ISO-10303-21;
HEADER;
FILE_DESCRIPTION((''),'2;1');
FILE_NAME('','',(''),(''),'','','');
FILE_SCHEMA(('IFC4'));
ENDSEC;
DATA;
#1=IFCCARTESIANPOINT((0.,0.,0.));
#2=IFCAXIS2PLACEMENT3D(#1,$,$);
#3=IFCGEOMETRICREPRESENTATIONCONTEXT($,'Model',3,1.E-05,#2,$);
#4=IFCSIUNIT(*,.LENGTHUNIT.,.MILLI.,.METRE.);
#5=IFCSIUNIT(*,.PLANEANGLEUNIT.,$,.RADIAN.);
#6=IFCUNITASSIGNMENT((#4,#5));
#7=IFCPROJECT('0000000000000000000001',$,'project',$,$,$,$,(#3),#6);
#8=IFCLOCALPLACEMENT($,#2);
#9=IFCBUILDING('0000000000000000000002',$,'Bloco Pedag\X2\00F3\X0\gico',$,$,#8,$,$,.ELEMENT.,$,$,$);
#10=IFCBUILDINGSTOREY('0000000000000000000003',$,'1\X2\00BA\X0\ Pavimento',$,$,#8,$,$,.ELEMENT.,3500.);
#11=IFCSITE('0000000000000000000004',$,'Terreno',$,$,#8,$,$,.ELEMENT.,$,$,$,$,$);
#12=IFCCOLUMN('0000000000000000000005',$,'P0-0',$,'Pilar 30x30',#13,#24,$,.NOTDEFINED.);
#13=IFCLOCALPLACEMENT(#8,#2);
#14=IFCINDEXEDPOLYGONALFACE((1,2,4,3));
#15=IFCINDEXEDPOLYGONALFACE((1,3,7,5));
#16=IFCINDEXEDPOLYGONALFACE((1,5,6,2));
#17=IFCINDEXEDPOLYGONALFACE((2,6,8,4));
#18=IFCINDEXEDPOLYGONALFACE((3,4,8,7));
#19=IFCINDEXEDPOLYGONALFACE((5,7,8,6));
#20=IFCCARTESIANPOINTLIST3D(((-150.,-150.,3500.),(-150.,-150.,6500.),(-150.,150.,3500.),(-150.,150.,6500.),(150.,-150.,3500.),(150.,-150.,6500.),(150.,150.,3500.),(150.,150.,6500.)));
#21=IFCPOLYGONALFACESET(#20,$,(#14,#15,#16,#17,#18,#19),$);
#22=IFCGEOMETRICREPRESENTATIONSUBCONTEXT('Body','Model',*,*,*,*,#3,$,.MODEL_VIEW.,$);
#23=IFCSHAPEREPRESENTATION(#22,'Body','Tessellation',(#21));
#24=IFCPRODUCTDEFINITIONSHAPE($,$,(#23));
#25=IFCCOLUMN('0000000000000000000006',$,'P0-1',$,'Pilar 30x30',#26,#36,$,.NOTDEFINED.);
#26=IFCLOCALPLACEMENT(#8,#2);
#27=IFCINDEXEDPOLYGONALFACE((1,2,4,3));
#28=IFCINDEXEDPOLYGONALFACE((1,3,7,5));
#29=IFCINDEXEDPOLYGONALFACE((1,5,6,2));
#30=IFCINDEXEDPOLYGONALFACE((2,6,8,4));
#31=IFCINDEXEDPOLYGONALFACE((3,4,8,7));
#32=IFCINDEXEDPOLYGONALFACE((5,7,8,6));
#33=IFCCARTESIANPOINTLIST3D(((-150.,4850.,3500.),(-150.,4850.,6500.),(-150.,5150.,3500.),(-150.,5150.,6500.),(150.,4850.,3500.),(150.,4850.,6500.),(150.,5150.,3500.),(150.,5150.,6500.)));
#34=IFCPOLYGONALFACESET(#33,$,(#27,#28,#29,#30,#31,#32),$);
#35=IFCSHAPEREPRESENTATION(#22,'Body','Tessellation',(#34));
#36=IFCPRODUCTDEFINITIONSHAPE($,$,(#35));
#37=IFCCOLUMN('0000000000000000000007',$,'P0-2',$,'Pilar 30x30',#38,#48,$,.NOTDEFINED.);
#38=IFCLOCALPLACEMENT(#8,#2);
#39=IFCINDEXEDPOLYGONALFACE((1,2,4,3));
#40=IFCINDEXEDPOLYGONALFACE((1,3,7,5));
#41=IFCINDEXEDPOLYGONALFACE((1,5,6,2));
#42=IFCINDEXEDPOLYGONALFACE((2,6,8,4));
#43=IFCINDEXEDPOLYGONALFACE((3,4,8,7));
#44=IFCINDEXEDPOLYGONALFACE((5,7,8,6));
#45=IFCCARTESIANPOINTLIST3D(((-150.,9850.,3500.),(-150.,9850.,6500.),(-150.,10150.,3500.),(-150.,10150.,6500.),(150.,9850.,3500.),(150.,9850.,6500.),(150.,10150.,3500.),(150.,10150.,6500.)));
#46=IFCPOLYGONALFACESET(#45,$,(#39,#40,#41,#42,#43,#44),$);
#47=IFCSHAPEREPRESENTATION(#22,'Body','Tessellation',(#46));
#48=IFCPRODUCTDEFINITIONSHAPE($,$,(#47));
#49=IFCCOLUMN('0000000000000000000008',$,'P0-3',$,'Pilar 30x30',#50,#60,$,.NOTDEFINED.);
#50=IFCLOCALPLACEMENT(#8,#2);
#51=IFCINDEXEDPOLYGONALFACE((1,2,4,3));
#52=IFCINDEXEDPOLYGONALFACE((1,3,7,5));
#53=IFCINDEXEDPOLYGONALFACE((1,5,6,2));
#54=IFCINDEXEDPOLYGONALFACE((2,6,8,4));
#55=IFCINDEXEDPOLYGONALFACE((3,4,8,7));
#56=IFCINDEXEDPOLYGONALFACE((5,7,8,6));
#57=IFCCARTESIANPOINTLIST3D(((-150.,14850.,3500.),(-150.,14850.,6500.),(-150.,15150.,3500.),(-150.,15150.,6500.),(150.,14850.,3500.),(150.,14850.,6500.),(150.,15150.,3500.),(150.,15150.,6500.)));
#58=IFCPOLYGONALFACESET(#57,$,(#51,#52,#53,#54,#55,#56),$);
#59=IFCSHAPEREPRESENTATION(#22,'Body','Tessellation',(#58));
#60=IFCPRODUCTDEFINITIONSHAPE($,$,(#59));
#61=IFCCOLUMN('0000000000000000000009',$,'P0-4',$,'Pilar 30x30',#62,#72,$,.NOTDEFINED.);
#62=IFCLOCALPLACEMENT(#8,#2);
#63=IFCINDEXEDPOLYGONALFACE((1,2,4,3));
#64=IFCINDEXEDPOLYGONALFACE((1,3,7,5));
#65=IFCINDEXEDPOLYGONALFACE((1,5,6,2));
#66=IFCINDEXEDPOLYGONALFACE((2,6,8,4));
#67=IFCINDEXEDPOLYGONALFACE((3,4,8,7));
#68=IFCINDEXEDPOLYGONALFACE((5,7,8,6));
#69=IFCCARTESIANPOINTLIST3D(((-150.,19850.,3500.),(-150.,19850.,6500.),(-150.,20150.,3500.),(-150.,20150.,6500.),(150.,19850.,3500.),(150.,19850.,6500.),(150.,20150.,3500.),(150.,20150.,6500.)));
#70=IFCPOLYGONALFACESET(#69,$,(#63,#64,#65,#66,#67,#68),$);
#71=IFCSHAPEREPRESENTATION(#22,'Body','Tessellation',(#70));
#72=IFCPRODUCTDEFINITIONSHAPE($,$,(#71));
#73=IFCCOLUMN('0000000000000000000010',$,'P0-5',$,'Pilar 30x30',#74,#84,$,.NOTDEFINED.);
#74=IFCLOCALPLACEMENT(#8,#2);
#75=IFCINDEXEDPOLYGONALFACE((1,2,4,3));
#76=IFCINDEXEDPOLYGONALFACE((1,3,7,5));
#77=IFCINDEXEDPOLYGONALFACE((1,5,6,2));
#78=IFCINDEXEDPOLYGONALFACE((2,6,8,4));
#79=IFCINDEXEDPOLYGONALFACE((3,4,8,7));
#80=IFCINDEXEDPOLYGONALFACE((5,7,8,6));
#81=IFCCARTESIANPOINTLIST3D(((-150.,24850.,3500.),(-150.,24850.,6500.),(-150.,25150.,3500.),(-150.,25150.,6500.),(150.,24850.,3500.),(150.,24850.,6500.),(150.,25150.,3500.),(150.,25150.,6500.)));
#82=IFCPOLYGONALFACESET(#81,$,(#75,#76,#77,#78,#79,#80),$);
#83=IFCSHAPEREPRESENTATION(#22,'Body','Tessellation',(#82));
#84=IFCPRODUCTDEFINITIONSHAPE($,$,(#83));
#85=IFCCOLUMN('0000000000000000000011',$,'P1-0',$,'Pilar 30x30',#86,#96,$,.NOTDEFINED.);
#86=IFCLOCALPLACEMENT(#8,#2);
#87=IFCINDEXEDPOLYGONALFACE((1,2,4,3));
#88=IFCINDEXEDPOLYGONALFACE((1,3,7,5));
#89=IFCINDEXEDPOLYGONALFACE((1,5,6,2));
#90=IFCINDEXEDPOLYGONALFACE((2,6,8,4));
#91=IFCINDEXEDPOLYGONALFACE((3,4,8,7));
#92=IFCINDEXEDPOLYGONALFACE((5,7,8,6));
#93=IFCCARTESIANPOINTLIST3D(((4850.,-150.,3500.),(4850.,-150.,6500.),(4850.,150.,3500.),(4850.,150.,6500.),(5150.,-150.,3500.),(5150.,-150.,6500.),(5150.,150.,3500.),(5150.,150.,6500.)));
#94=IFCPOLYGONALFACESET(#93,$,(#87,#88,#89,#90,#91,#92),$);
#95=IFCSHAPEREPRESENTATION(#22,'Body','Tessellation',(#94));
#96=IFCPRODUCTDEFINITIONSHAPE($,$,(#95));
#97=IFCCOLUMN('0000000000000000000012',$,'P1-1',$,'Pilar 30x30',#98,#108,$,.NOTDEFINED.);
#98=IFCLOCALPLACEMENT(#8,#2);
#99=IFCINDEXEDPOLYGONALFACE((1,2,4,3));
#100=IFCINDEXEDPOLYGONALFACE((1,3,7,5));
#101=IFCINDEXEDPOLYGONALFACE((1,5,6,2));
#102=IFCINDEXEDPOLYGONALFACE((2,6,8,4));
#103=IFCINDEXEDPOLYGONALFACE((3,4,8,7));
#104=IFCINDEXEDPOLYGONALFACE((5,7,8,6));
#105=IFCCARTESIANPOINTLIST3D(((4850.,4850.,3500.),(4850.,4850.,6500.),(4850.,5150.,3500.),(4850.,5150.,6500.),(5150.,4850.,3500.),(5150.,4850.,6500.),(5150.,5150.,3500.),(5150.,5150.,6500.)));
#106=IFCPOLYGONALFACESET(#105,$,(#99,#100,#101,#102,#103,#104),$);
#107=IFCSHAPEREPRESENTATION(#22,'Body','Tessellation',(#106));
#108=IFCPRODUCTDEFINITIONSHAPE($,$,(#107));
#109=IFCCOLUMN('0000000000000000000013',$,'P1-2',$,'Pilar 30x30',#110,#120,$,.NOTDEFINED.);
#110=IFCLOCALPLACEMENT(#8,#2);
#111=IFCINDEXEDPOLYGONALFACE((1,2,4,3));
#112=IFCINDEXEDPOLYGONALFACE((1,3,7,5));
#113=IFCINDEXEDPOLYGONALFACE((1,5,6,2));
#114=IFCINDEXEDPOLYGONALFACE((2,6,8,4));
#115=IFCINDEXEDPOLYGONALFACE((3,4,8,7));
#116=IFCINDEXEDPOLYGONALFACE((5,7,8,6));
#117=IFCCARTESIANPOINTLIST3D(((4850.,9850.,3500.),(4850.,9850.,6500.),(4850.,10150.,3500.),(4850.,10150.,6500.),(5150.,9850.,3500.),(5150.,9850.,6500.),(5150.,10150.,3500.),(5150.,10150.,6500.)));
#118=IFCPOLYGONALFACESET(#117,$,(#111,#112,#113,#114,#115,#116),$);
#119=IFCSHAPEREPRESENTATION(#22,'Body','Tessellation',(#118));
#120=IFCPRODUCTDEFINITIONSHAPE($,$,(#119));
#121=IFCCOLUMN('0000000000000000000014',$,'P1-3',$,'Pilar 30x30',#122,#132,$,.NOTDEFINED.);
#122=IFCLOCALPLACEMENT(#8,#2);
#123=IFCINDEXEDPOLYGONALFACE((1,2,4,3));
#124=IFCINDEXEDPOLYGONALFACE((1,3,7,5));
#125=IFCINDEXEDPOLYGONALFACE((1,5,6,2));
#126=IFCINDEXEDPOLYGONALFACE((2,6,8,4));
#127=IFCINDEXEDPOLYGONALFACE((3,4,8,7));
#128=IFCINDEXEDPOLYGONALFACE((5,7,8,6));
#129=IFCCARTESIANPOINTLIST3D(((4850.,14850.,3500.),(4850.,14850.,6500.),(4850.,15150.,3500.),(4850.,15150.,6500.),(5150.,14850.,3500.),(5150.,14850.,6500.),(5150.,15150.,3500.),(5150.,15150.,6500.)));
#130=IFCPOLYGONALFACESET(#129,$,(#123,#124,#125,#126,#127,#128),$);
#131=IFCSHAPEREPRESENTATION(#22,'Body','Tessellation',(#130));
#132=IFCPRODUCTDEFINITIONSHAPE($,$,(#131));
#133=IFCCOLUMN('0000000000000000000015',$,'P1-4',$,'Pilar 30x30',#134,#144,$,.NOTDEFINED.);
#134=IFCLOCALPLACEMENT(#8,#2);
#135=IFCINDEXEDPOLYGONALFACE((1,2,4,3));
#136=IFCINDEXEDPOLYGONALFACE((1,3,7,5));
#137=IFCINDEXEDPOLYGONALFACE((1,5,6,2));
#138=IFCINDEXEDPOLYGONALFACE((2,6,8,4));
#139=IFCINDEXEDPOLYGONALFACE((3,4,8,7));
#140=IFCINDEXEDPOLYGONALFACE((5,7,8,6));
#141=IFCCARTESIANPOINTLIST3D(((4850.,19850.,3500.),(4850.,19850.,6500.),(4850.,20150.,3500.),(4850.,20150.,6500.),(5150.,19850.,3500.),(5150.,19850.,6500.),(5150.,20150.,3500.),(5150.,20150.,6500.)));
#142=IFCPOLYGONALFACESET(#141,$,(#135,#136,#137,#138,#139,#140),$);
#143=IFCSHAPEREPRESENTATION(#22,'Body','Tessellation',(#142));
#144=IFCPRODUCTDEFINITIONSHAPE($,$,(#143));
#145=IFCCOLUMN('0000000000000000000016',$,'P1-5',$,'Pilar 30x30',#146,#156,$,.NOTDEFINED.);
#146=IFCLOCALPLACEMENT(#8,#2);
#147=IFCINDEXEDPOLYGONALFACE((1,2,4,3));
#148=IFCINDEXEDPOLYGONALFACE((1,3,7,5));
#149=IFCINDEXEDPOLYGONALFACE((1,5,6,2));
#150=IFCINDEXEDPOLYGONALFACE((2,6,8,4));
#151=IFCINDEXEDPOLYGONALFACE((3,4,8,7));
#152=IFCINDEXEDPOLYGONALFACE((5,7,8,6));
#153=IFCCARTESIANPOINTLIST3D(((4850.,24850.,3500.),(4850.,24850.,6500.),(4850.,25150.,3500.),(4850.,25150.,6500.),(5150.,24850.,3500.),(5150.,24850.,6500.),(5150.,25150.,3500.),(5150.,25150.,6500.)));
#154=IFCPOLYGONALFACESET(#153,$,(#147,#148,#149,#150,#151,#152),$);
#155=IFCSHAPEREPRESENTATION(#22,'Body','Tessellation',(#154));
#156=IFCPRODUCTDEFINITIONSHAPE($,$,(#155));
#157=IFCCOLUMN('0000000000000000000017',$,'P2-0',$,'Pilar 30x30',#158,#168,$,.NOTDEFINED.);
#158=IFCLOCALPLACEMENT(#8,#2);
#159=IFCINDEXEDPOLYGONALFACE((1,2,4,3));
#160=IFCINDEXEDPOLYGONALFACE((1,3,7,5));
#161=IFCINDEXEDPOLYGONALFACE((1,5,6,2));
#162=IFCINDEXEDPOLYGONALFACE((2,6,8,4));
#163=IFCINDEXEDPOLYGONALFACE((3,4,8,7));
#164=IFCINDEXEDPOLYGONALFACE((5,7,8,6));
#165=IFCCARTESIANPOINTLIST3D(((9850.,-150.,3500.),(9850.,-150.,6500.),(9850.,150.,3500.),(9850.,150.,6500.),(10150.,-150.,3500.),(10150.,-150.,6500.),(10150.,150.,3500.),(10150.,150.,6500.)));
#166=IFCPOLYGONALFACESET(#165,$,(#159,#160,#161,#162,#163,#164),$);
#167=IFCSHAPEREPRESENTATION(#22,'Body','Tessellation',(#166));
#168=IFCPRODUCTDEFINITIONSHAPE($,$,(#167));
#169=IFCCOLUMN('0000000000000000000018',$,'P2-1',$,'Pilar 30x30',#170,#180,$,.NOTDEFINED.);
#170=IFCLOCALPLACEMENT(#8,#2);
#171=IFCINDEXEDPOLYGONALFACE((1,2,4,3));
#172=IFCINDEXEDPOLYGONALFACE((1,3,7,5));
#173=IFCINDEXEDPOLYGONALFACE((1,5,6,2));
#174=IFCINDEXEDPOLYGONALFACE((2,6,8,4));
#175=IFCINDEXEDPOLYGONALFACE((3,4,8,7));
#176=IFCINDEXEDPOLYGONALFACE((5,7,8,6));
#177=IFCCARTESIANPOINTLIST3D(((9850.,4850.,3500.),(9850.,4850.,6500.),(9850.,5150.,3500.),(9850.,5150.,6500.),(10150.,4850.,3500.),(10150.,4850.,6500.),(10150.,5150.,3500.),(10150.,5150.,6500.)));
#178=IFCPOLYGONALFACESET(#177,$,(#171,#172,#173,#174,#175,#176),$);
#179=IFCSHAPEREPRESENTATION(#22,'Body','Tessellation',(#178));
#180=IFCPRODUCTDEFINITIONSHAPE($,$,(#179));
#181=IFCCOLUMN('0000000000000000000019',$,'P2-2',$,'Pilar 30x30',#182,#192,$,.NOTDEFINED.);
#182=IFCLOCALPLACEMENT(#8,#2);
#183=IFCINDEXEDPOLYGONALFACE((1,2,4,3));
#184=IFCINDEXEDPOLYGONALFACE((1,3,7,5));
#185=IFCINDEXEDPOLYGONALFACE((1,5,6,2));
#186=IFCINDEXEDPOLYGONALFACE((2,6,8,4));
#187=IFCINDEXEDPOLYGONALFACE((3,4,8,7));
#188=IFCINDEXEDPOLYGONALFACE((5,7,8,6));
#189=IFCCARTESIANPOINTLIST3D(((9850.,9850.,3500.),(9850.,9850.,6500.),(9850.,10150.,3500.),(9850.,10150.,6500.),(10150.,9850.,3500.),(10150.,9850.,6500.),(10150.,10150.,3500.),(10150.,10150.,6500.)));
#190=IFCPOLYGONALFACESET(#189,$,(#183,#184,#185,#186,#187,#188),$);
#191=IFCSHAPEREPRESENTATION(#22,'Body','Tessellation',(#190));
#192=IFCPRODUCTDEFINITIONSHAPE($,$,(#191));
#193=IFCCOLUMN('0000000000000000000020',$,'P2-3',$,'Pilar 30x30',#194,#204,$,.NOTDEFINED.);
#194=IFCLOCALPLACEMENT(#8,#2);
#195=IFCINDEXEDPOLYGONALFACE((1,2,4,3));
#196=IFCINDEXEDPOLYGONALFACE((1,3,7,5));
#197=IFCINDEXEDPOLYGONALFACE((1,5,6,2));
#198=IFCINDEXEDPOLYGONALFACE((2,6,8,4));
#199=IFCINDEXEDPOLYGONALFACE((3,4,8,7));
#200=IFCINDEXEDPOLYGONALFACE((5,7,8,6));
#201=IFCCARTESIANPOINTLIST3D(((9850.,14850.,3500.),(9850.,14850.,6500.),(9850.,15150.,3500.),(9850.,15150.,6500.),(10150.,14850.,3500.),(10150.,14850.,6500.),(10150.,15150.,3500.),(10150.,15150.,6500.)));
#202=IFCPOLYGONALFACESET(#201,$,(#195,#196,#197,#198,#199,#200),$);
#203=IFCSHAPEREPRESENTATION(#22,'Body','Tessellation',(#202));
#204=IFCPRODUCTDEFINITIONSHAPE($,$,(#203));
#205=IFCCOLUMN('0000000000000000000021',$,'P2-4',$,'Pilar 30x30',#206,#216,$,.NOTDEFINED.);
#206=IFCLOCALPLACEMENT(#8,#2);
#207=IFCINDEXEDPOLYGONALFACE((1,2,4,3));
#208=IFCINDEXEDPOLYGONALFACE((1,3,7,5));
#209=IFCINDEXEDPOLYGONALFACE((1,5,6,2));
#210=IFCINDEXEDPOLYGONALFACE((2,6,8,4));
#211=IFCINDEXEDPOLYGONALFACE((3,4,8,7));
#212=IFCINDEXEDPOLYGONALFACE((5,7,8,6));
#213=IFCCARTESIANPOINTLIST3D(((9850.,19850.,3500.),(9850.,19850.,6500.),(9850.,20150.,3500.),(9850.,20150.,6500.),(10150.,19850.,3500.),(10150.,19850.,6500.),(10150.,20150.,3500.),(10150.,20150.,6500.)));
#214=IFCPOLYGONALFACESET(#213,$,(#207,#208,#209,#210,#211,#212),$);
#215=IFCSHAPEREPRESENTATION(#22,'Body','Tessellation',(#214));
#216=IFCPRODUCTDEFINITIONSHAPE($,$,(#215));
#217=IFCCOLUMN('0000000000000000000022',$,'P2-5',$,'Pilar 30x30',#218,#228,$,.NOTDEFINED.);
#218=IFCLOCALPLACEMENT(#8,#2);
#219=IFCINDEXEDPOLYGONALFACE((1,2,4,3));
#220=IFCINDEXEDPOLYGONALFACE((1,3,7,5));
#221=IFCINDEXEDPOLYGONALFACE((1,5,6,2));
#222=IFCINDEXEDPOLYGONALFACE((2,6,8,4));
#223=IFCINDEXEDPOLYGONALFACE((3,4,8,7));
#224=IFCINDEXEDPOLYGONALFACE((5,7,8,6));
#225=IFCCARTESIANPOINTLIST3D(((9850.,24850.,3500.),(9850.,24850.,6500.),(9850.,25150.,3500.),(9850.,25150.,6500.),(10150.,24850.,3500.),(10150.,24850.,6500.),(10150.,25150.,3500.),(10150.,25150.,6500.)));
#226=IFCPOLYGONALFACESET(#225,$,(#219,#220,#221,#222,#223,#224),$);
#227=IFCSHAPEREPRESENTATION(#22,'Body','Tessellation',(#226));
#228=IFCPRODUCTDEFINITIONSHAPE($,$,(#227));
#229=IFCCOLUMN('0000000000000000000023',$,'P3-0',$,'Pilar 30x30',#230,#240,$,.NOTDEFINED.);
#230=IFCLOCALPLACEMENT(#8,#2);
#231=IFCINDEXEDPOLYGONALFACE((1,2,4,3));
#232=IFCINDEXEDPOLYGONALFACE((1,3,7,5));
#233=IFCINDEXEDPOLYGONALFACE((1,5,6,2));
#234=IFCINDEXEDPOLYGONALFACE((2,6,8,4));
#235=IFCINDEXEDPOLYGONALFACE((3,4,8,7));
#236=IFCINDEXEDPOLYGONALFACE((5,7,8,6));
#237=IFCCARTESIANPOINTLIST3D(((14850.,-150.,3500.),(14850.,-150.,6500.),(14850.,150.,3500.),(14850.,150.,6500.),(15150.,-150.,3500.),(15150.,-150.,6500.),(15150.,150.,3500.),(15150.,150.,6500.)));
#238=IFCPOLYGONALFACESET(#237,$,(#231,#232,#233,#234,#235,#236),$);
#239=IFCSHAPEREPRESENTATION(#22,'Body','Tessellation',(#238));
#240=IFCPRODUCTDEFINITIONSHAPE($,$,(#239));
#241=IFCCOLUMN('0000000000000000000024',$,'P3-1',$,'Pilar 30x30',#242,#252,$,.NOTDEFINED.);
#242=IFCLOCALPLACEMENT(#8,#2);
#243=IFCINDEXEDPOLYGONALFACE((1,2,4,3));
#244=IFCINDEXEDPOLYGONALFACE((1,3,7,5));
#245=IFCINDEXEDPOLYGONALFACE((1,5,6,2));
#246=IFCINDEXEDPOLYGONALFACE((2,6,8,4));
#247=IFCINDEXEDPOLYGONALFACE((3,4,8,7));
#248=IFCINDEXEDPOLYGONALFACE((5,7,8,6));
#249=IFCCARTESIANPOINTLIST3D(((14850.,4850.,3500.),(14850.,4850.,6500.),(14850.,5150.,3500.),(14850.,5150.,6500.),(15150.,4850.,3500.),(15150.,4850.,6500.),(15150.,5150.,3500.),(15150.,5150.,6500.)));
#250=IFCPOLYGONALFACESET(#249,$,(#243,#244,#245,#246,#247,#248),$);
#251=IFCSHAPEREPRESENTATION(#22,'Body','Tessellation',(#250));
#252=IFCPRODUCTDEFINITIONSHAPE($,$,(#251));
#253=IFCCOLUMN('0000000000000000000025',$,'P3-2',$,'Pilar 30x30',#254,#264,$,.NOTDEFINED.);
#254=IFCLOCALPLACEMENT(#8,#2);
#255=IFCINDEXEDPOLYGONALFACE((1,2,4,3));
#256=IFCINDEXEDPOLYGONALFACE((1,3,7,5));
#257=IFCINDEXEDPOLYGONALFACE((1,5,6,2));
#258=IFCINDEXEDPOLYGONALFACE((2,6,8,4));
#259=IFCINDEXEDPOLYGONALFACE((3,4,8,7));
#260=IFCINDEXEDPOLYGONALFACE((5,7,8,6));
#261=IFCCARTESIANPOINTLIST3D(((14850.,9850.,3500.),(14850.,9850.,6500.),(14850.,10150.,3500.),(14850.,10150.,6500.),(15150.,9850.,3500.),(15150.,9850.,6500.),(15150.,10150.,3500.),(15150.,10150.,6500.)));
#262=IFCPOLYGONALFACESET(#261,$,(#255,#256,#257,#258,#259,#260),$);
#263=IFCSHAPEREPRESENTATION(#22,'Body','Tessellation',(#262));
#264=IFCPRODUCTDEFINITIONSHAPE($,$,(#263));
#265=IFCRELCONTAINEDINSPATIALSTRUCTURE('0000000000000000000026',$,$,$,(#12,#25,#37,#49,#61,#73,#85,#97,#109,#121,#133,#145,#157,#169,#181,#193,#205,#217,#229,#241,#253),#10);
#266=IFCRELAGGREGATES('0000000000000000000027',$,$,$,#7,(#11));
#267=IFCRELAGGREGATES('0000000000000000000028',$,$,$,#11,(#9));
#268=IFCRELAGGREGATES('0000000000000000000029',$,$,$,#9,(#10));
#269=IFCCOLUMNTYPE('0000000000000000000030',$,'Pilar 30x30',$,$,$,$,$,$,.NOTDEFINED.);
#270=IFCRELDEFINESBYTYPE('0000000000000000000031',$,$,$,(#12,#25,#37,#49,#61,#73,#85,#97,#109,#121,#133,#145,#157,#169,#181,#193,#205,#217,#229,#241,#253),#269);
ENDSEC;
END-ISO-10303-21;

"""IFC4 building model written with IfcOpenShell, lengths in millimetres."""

from ifc_helpers import new_model, si_unit, frame, origin, origin_2d, place, context, subcontext, project, spatial, rectangle, extrude, type_object, element, save


model = new_model("IFC4")

# Units and contexts
model_context = context("Model", 3, precision=1e-05, world=origin())
body_context = subcontext(model_context, "Body", "Model", "MODEL_VIEW")
ifc_project = project(units=[si_unit("LENGTHUNIT", "METRE", prefix="MILLI"), si_unit("PLANEANGLEUNIT", "RADIAN")], contexts=[model_context])

# Site, building, storey
placement = place(None, origin())
site = spatial("IfcSite", under=ifc_project, at=placement, Name="Terreno", CompositionType="ELEMENT")
building = spatial("IfcBuilding", under=site, at=placement, Name="Bloco Pedagógico", CompositionType="ELEMENT")
storey = spatial("IfcBuildingStorey", under=building, at=placement, Name="1º Pavimento", CompositionType="ELEMENT", Elevation=3500.0)

# Columns
column_type = type_object("IfcColumnType", Name="Pilar 30x30", PredefinedType="NOTDEFINED")
for number, where, z_axis, x_axis, name in (
    (1, (0.0, 0.0, 3500.0), (0.0, 0.0, 1.0), (1.0, 0.0, 0.0), "P0-0"),
    (2, (0.0, 5000.0, 3500.0), (0.0, 0.0, 1.0), (1.0, 0.0, 0.0), "P0-1"),
    (3, (0.0, 10000.0, 3500.0), (0.0, 0.0, 1.0), (1.0, 0.0, 0.0), "P0-2"),
    (4, (0.0, 15000.0, 3500.0), (0.0, 0.0, 1.0), (1.0, 0.0, 0.0), "P0-3"),
    (5, (0.0, 20000.0, 3500.0), (0.0, 0.0, 1.0), (1.0, 0.0, 0.0), "P0-4"),
    (6, (0.0, 25000.0, 3500.0), (0.0, 0.0, 1.0), (1.0, 0.0, 0.0), "P0-5"),
    (7, (5000.0, 0.0, 3500.0), (0.0, 0.0, 1.0), (1.0, 0.0, 0.0), "P1-0"),
    (8, (5000.0, 5000.0, 3500.0), (0.0, 0.0, 1.0), (1.0, 0.0, 0.0), "P1-1"),
    (9, (5000.0, 10000.0, 3500.0), (0.0, 0.0, 1.0), (1.0, 0.0, 0.0), "P1-2"),
    (10, (5000.0, 15000.0, 3500.0), (0.0, 0.0, 1.0), (1.0, 0.0, 0.0), "P1-3"),
    (11, (5000.0, 20000.0, 3500.0), (0.0, 0.0, 1.0), (1.0, 0.0, 0.0), "P1-4"),
    (12, (5000.0, 25000.0, 3500.0), (0.0, 0.0, 1.0), (1.0, 0.0, 0.0), "P1-5"),
    (13, (10000.0, 0.0, 3500.0), (0.0, 0.0, 1.0), (1.0, 0.0, 0.0), "P2-0"),
    (14, (10000.0, 5000.0, 3500.0), (0.0, 0.0, 1.0), (1.0, 0.0, 0.0), "P2-1"),
    (15, (10000.0, 10000.0, 3500.0), (0.0, 0.0, 1.0), (1.0, 0.0, 0.0), "P2-2"),
    (16, (10000.0, 15000.0, 3500.0), (0.0, 0.0, 1.0), (1.0, 0.0, 0.0), "P2-3"),
    (17, (10000.0, 20000.0, 3500.0), (0.0, 0.0, 1.0), (1.0, 0.0, 0.0), "P2-4"),
    (18, (10000.0, 25000.0, 3500.0), (0.0, 0.0, 1.0), (1.0, 0.0, 0.0), "P2-5"),
    (19, (15000.0, 0.0, 3500.0), (0.0, 0.0, 1.0), (1.0, 0.0, 0.0), "P3-0"),
    (20, (15000.0, 5000.0, 3500.0), (0.0, 0.0, 1.0), (1.0, 0.0, 0.0), "P3-1"),
    (21, (15000.0, 10000.0, 3500.0), (0.0, 0.0, 1.0), (1.0, 0.0, 0.0), "P3-2"),
):
    element("IfcColumn", number, at=place(None, frame(where, z_axis=z_axis, x_axis=x_axis)), inside=storey, type_object=column_type, Name=name, ObjectType="Pilar 30x30", PredefinedType="NOTDEFINED", context=body_context, shape_type="SweptSolid", body=[
        extrude(rectangle(XDim=300.0, YDim=300.0, at=origin_2d()), None, (0.0, 0.0, 1.0), 3000.0),
    ])

save(model, "model.ifc")
